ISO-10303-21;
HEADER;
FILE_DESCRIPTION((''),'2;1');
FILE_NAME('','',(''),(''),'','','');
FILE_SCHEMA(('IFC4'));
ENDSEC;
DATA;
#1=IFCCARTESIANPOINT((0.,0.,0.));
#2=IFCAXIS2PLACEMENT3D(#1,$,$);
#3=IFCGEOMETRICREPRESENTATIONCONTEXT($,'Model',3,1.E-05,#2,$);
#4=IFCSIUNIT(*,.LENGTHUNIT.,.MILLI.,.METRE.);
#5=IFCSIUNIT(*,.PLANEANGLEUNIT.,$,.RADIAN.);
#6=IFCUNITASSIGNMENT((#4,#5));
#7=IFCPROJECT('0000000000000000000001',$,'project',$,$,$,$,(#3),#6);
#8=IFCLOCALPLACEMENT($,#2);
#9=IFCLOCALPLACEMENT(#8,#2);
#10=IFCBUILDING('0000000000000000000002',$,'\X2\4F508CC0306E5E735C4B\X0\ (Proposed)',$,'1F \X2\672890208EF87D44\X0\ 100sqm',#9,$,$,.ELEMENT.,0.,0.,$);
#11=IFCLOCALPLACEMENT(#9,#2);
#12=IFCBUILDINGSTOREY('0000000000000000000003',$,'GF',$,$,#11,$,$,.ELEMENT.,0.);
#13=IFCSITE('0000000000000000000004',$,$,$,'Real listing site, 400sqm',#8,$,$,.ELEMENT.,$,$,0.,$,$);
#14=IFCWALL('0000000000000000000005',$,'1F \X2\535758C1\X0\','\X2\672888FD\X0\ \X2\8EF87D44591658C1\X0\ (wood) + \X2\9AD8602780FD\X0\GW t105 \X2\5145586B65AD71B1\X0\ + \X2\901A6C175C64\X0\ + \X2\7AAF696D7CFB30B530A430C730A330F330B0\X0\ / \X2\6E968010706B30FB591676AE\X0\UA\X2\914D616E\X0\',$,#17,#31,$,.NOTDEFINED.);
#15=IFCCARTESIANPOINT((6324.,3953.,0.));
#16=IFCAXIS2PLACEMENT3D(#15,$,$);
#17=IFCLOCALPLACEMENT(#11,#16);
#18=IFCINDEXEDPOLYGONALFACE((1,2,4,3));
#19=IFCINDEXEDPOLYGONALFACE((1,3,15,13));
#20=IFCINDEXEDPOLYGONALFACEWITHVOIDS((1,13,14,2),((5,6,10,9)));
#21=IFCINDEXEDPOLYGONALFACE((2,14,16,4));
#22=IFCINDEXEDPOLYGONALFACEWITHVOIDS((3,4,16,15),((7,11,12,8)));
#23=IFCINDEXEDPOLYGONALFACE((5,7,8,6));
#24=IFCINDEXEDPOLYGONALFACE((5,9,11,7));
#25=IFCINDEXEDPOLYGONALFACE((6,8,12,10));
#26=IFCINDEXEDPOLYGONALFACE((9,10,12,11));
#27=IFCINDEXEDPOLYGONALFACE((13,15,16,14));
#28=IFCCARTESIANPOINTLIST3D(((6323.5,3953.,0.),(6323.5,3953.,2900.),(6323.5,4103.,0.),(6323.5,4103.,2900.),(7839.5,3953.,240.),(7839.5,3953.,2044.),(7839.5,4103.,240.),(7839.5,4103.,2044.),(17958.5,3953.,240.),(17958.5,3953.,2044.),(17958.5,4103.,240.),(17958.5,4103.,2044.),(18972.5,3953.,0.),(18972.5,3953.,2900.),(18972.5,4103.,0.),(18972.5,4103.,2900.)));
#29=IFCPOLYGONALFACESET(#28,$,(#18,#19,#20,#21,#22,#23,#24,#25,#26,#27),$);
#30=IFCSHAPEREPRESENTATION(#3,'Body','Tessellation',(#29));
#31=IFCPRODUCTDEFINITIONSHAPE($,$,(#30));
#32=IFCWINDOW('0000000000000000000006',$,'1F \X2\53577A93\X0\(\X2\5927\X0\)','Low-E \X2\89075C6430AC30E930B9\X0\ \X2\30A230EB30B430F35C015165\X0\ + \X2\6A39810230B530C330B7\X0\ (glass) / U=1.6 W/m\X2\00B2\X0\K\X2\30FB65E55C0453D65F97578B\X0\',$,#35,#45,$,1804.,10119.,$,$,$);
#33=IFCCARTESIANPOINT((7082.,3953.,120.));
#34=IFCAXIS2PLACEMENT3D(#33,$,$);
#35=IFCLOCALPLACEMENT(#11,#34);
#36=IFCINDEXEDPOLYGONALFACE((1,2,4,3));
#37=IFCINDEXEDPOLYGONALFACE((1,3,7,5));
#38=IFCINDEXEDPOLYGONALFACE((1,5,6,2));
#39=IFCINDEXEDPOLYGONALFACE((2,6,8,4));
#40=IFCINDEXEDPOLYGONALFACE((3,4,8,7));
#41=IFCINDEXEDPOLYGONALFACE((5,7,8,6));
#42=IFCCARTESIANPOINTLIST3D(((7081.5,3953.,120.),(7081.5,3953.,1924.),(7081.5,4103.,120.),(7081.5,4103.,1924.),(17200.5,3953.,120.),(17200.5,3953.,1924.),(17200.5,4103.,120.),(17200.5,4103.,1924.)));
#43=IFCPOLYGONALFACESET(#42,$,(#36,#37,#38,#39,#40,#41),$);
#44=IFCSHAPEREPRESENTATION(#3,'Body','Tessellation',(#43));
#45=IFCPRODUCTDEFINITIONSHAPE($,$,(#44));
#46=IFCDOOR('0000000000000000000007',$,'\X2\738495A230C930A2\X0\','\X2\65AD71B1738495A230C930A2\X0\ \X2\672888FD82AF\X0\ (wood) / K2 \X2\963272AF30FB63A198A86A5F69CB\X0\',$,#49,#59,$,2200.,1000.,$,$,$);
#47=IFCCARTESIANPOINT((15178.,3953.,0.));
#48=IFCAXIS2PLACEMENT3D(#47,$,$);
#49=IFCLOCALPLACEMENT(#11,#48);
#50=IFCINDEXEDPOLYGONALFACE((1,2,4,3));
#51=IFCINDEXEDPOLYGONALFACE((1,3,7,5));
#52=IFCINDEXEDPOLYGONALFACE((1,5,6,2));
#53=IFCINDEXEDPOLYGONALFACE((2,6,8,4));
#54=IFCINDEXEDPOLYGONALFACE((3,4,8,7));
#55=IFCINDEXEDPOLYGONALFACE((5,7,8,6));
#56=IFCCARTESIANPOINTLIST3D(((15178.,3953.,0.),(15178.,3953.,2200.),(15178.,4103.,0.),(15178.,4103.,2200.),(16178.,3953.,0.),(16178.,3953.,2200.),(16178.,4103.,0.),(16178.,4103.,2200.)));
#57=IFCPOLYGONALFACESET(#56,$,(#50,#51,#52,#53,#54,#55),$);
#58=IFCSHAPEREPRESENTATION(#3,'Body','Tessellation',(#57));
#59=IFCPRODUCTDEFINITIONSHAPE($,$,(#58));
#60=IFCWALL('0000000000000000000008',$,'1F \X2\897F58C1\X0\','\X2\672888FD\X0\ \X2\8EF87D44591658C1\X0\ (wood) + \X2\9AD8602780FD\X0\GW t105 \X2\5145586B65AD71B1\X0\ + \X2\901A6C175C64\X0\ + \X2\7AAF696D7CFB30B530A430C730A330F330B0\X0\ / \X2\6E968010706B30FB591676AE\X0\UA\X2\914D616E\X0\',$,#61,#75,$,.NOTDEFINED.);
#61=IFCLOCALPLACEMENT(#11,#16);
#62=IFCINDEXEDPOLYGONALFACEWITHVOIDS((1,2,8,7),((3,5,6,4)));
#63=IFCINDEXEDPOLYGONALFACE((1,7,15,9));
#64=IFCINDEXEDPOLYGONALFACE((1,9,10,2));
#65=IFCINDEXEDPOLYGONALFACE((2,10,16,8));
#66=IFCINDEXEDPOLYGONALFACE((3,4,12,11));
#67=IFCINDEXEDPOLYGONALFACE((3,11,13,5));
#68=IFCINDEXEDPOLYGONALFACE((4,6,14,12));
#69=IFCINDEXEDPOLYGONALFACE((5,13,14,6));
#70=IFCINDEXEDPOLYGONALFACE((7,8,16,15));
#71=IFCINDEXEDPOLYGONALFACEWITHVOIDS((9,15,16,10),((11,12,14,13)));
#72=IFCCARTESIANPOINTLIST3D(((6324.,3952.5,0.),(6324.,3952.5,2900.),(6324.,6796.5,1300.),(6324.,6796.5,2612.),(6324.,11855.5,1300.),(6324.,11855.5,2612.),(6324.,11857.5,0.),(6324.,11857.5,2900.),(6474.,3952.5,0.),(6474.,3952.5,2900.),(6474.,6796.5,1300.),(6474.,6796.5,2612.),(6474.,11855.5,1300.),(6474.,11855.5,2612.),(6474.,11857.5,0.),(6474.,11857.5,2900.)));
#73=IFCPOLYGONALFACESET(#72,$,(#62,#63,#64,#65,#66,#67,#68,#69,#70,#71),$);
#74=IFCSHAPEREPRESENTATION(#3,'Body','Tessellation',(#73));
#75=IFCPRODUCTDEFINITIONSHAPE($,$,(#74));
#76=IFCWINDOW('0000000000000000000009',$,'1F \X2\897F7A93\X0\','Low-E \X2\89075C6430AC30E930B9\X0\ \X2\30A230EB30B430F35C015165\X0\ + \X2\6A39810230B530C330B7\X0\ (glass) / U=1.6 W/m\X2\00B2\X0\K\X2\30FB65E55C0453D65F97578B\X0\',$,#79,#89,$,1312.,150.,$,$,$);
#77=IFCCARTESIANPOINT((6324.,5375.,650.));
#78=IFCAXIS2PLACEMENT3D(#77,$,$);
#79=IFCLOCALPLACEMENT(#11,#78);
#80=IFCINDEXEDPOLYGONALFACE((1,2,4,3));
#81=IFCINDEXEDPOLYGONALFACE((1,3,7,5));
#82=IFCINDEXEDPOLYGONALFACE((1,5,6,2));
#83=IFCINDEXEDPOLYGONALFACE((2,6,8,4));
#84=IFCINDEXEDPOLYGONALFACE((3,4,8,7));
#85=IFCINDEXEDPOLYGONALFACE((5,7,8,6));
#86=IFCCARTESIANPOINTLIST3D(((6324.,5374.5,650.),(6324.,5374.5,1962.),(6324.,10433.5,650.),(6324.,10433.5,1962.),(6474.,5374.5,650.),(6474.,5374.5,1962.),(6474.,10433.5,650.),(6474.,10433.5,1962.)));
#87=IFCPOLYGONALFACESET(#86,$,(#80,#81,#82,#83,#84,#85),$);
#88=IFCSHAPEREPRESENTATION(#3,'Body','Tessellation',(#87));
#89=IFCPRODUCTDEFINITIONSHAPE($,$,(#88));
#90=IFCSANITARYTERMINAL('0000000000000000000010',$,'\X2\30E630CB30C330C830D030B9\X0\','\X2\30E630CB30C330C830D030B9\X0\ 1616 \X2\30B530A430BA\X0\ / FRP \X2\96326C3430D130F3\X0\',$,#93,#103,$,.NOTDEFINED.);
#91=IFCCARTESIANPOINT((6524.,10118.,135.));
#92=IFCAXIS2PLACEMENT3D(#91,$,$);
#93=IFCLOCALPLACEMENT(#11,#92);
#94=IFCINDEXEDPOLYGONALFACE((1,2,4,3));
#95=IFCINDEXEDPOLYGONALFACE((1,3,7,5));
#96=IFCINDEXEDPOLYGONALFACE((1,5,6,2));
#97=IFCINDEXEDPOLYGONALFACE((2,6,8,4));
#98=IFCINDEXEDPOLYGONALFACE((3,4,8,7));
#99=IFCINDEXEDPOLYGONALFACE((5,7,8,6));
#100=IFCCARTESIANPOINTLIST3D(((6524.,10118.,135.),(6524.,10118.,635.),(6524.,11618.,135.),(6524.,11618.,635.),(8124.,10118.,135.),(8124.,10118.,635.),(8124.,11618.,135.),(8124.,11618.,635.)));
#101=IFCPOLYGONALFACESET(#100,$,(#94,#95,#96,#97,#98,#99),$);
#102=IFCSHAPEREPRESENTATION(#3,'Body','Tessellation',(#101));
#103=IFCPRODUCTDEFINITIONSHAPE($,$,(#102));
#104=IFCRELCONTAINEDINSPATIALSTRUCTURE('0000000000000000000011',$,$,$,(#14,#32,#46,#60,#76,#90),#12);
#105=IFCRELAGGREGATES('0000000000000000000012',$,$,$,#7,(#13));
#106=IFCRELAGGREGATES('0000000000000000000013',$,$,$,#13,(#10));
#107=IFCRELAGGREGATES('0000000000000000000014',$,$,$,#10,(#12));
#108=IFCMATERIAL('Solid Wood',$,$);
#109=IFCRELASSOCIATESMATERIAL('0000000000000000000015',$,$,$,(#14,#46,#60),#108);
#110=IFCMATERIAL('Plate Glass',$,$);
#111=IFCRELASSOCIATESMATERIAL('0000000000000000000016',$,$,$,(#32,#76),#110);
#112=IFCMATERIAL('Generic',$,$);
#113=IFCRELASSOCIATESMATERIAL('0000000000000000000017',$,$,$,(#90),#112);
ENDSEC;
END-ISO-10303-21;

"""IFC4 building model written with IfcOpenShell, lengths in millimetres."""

from ifc_helpers import new_model, si_unit, frame, frame_2d, origin, place, context, project, spatial, rectangle, extrude, material, element, fill, save


model = new_model("IFC4")

# Units and contexts
model_context = context("Model", 3, precision=1e-05, world=origin())
ifc_project = project(units=[si_unit("LENGTHUNIT", "METRE", prefix="MILLI"), si_unit("PLANEANGLEUNIT", "RADIAN")], contexts=[model_context])

# Site, building, storey
site_placement = place(None, origin())
site = spatial("IfcSite", under=ifc_project, at=site_placement, ObjectType="Real listing site, 400sqm", CompositionType="ELEMENT", RefElevation=0.0)
building_placement = place(site_placement, origin())
building = spatial("IfcBuilding", under=site, at=building_placement, Name="佐賀の平屋 (Proposed)", ObjectType="1F 木造軸組 100sqm", CompositionType="ELEMENT", ElevationOfRefHeight=0.0, ElevationOfTerrain=0.0)
storey_placement = place(building_placement, origin())
storey = spatial("IfcBuildingStorey", under=building, at=storey_placement, Name="GF", CompositionType="ELEMENT", Elevation=0.0)

# Shared definitions
ifc_material_1 = material(Name="Solid Wood")

# Wall, openings, window, door
wall_1_placement = place(storey_placement, frame((6324.0, 3953.0, 0.0)))
wall_1 = element("IfcWall", 1, at=wall_1_placement, inside=storey, material=ifc_material_1, Name="1F 南壁", Description="木製 軸組外壁 (wood) + 高性能GW t105 充填断熱 + 通気層 + 窯業系サイディング / 準耐火・外皮UA配慮", PredefinedType="NOTDEFINED", context=model_context, shape_type="SweptSolid", body=[
    extrude(rectangle(XDim=12649.0, YDim=150.0, at=frame_2d((6324.0, 75.0))), frame((6324.0, 3953.0, 0.0)), (0.0, 0.0, 1.0), 2900.0),
])
opening_1_placement = place(storey_placement, frame((7082.0, 3953.0, 120.0)))
opening_1 = element("IfcOpeningElement", 2, at=opening_1_placement, cuts=wall_1, PredefinedType="NOTDEFINED", context=model_context, shape_type="SweptSolid", body=[
    extrude(rectangle(XDim=10119.0, YDim=150.0, at=frame_2d((5059.0, 75.0))), frame((7082.0, 3953.0, 120.0)), (0.0, 0.0, 1.0), 1804.0),
])
opening_2_placement = place(storey_placement, frame((15178.0, 3953.0, 0.0)))
opening_2 = element("IfcOpeningElement", 3, at=opening_2_placement, cuts=wall_1, PredefinedType="NOTDEFINED", context=model_context, shape_type="SweptSolid", body=[
    extrude(rectangle(XDim=1000.0, YDim=150.0, at=frame_2d((500.0, 75.0))), frame((15178.0, 3953.0, 0.0)), (0.0, 0.0, 1.0), 2200.0),
])
ifc_material_2 = material(Name="Plate Glass")
window_1_placement = place(storey_placement, frame((7082.0, 3953.0, 120.0)))
window_1 = element("IfcWindow", 4, at=window_1_placement, inside=storey, material=ifc_material_2, Name="1F 南窓(大)", Description="Low-E 複層ガラス アルゴン封入 + 樹脂サッシ (glass) / U=1.6 W/m²K・日射取得型", OverallHeight=1804.0, OverallWidth=10119.0, context=model_context, shape_type="SweptSolid", body=[
    extrude(rectangle(XDim=10119.0, YDim=150.0, at=frame_2d((5059.0, 75.0))), frame((7082.0, 3953.0, 120.0)), (0.0, 0.0, 1.0), 1804.0),
])
fill(opening_1, window_1)
door_placement = place(storey_placement, frame((15178.0, 3953.0, 0.0)))
door = element("IfcDoor", 5, at=door_placement, inside=storey, material=ifc_material_1, Name="玄関ドア", Description="断熱玄関ドア 木製芯 (wood) / K2 防犯・採風機構", OverallHeight=2200.0, OverallWidth=1000.0, context=model_context, shape_type="SweptSolid", body=[
    extrude(rectangle(XDim=1000.0, YDim=150.0, at=frame_2d((500.0, 75.0))), frame((15178.0, 3953.0, 0.0)), (0.0, 0.0, 1.0), 2200.0),
])
fill(opening_2, door)

# Wall, opening, window
wall_2_placement = place(storey_placement, frame((6324.0, 3953.0, 0.0)))
wall_2 = element("IfcWall", 6, at=wall_2_placement, inside=storey, material=ifc_material_1, Name="1F 西壁", Description="木製 軸組外壁 (wood) + 高性能GW t105 充填断熱 + 通気層 + 窯業系サイディング / 準耐火・外皮UA配慮", PredefinedType="NOTDEFINED", context=model_context, shape_type="SweptSolid", body=[
    extrude(rectangle(XDim=150.0, YDim=7905.0, at=frame_2d((75.0, 3952.0))), frame((6324.0, 3953.0, 0.0)), (0.0, 0.0, 1.0), 2900.0),
])
opening_3_placement = place(storey_placement, frame((6324.0, 5375.0, 650.0)))
opening_3 = element("IfcOpeningElement", 7, at=opening_3_placement, cuts=wall_2, PredefinedType="NOTDEFINED", context=model_context, shape_type="SweptSolid", body=[
    extrude(rectangle(XDim=150.0, YDim=5059.0, at=frame_2d((75.0, 2529.0))), frame((6324.0, 5375.0, 650.0)), (0.0, 0.0, 1.0), 1312.0),
])
window_2_placement = place(storey_placement, frame((6324.0, 5375.0, 650.0)))
window_2 = element("IfcWindow", 8, at=window_2_placement, inside=storey, material=ifc_material_2, Name="1F 西窓", Description="Low-E 複層ガラス アルゴン封入 + 樹脂サッシ (glass) / U=1.6 W/m²K・日射取得型", OverallHeight=1312.0, OverallWidth=150.0, context=model_context, shape_type="SweptSolid", body=[
    extrude(rectangle(XDim=150.0, YDim=5059.0, at=frame_2d((75.0, 2529.0))), frame((6324.0, 5375.0, 650.0)), (0.0, 0.0, 1.0), 1312.0),
])
fill(opening_3, window_2)

# Shared definitions
ifc_material_3 = material(Name="Generic")

# Sanitary terminal
sanitary_terminal_placement = place(storey_placement, frame((6524.0, 10118.0, 135.0)))
element("IfcSanitaryTerminal", 9, at=sanitary_terminal_placement, inside=storey, material=ifc_material_3, Name="ユニットバス", Description="ユニットバス 1616 サイズ / FRP 防水パン", PredefinedType="NOTDEFINED", context=model_context, shape_type="SweptSolid", body=[
    extrude(rectangle(XDim=1600.0, YDim=1500.0, at=frame_2d((800.0, 750.0))), frame((6524.0, 10118.0, 135.0)), (0.0, 0.0, 1.0), 500.0),
])

save(model, "model.ifc")
